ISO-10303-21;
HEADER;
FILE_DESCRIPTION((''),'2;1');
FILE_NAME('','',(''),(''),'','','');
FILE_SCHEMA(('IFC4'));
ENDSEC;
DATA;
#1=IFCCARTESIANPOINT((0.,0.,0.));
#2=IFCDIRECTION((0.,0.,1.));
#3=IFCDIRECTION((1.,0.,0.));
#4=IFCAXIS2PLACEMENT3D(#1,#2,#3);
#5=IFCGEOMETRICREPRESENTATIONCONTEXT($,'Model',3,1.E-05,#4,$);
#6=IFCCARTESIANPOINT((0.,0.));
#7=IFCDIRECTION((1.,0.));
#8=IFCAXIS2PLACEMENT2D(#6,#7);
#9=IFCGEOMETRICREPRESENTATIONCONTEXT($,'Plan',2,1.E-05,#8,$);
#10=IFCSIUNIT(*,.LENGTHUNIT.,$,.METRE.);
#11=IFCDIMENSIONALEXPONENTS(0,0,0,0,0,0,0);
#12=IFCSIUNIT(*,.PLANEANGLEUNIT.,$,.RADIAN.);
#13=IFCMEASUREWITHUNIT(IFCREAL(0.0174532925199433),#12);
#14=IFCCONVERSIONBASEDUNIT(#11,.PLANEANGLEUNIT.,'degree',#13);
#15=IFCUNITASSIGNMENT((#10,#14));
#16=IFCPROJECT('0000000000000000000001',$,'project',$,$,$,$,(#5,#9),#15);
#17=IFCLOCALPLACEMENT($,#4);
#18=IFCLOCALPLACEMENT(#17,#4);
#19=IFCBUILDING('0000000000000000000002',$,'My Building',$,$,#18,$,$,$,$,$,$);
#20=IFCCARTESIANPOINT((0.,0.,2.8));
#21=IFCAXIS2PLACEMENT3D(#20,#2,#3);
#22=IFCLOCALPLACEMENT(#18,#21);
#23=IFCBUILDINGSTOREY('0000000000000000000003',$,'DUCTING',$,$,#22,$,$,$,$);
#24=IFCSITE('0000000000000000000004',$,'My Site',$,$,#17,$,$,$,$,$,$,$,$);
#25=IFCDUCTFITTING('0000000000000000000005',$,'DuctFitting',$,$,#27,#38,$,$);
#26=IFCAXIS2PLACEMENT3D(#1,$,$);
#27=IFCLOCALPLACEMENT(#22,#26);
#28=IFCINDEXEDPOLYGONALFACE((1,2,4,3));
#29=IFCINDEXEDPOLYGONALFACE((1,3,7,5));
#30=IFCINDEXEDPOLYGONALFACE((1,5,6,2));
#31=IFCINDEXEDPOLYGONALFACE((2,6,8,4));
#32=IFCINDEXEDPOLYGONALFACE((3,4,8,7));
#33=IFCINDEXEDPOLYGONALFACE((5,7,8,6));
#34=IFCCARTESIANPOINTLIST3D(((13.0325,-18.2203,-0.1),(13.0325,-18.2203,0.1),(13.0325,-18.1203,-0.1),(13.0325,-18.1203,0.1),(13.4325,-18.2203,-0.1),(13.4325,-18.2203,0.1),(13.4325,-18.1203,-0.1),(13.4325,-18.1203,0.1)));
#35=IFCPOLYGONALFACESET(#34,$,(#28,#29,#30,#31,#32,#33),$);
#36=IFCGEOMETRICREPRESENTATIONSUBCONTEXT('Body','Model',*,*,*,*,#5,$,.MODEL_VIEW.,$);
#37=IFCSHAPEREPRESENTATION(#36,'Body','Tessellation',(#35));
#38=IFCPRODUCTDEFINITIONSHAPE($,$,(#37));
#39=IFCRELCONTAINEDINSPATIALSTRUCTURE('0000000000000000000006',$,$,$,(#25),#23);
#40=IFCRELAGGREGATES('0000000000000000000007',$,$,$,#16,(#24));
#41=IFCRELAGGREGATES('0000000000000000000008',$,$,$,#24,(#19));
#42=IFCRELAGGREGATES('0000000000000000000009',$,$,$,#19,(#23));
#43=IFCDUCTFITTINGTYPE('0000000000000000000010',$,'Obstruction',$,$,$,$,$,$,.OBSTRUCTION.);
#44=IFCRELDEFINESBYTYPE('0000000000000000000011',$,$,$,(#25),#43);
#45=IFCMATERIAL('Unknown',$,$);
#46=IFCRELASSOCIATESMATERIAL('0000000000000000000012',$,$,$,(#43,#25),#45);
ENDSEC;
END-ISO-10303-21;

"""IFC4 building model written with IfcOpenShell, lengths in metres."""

from ifc_helpers import new_model, entity, si_unit, converted_unit, frame, origin_with_axes, origin_2d_with_axis, place, context, subcontext, project, spatial, rectangle, extrude, material, material_profile, profile_set, profile_usage, type_object, element, save


model = new_model("IFC4")

# Units and contexts
model_context = context("Model", 3, precision=1e-05, world=origin_with_axes())
plan_context = context("Plan", 2, precision=1e-05, world=origin_2d_with_axis())
body_context = subcontext(model_context, "Body", "Model", "MODEL_VIEW")
ifc_project = project(units=[si_unit("LENGTHUNIT", "METRE"), converted_unit("PLANEANGLEUNIT", "degree", entity("IfcReal", 0.0174532925199433), si_unit("PLANEANGLEUNIT", "RADIAN"), dimensions=[0, 0, 0, 0, 0, 0, 0])], contexts=[model_context, plan_context])

# Site, building, storey
site_placement = place(None, origin_with_axes())
site = spatial("IfcSite", under=ifc_project, at=site_placement, Name="My Site")
building_placement = place(site_placement, origin_with_axes())
building = spatial("IfcBuilding", under=site, at=building_placement, Name="My Building")
storey_placement = place(building_placement, frame((0.0, 0.0, 2.8), z_axis=(0.0, 0.0, 1.0), x_axis=(1.0, 0.0, 0.0)))
storey = spatial("IfcBuildingStorey", under=building, at=storey_placement, Name="DUCTING")

# Shared definitions
ifc_material = material(Name="Unknown")

# Duct fitting
ifc_material_profile_1 = material_profile(ifc_material, rectangle(XDim=0.4, YDim=0.2))
ifc_profile_set_1 = profile_set([ifc_material_profile_1])
duct_fitting_type_1 = type_object("IfcDuctFittingType", Name="Obstruction", PredefinedType="OBSTRUCTION", material=ifc_profile_set_1)
ifc_profile_usage_1 = profile_usage(ifc_profile_set_1, cardinal=5)
duct_fitting_1_placement = place(storey_placement, frame((13.2325, -18.2203, 0.0), z_axis=(0.0, 1.0, 0.0), x_axis=(-1.0, 0.0, 0.0)))
element("IfcDuctFitting", 1, at=duct_fitting_1_placement, inside=storey, type_object=duct_fitting_type_1, material=ifc_profile_usage_1, Name="DuctFitting", context=body_context, shape_type="SweptSolid", body=[
    extrude(rectangle(XDim=0.4, YDim=0.2), origin_with_axes(), (0.0, 0.0, 1.0), 0.1),
])

save(model, "model.ifc")
